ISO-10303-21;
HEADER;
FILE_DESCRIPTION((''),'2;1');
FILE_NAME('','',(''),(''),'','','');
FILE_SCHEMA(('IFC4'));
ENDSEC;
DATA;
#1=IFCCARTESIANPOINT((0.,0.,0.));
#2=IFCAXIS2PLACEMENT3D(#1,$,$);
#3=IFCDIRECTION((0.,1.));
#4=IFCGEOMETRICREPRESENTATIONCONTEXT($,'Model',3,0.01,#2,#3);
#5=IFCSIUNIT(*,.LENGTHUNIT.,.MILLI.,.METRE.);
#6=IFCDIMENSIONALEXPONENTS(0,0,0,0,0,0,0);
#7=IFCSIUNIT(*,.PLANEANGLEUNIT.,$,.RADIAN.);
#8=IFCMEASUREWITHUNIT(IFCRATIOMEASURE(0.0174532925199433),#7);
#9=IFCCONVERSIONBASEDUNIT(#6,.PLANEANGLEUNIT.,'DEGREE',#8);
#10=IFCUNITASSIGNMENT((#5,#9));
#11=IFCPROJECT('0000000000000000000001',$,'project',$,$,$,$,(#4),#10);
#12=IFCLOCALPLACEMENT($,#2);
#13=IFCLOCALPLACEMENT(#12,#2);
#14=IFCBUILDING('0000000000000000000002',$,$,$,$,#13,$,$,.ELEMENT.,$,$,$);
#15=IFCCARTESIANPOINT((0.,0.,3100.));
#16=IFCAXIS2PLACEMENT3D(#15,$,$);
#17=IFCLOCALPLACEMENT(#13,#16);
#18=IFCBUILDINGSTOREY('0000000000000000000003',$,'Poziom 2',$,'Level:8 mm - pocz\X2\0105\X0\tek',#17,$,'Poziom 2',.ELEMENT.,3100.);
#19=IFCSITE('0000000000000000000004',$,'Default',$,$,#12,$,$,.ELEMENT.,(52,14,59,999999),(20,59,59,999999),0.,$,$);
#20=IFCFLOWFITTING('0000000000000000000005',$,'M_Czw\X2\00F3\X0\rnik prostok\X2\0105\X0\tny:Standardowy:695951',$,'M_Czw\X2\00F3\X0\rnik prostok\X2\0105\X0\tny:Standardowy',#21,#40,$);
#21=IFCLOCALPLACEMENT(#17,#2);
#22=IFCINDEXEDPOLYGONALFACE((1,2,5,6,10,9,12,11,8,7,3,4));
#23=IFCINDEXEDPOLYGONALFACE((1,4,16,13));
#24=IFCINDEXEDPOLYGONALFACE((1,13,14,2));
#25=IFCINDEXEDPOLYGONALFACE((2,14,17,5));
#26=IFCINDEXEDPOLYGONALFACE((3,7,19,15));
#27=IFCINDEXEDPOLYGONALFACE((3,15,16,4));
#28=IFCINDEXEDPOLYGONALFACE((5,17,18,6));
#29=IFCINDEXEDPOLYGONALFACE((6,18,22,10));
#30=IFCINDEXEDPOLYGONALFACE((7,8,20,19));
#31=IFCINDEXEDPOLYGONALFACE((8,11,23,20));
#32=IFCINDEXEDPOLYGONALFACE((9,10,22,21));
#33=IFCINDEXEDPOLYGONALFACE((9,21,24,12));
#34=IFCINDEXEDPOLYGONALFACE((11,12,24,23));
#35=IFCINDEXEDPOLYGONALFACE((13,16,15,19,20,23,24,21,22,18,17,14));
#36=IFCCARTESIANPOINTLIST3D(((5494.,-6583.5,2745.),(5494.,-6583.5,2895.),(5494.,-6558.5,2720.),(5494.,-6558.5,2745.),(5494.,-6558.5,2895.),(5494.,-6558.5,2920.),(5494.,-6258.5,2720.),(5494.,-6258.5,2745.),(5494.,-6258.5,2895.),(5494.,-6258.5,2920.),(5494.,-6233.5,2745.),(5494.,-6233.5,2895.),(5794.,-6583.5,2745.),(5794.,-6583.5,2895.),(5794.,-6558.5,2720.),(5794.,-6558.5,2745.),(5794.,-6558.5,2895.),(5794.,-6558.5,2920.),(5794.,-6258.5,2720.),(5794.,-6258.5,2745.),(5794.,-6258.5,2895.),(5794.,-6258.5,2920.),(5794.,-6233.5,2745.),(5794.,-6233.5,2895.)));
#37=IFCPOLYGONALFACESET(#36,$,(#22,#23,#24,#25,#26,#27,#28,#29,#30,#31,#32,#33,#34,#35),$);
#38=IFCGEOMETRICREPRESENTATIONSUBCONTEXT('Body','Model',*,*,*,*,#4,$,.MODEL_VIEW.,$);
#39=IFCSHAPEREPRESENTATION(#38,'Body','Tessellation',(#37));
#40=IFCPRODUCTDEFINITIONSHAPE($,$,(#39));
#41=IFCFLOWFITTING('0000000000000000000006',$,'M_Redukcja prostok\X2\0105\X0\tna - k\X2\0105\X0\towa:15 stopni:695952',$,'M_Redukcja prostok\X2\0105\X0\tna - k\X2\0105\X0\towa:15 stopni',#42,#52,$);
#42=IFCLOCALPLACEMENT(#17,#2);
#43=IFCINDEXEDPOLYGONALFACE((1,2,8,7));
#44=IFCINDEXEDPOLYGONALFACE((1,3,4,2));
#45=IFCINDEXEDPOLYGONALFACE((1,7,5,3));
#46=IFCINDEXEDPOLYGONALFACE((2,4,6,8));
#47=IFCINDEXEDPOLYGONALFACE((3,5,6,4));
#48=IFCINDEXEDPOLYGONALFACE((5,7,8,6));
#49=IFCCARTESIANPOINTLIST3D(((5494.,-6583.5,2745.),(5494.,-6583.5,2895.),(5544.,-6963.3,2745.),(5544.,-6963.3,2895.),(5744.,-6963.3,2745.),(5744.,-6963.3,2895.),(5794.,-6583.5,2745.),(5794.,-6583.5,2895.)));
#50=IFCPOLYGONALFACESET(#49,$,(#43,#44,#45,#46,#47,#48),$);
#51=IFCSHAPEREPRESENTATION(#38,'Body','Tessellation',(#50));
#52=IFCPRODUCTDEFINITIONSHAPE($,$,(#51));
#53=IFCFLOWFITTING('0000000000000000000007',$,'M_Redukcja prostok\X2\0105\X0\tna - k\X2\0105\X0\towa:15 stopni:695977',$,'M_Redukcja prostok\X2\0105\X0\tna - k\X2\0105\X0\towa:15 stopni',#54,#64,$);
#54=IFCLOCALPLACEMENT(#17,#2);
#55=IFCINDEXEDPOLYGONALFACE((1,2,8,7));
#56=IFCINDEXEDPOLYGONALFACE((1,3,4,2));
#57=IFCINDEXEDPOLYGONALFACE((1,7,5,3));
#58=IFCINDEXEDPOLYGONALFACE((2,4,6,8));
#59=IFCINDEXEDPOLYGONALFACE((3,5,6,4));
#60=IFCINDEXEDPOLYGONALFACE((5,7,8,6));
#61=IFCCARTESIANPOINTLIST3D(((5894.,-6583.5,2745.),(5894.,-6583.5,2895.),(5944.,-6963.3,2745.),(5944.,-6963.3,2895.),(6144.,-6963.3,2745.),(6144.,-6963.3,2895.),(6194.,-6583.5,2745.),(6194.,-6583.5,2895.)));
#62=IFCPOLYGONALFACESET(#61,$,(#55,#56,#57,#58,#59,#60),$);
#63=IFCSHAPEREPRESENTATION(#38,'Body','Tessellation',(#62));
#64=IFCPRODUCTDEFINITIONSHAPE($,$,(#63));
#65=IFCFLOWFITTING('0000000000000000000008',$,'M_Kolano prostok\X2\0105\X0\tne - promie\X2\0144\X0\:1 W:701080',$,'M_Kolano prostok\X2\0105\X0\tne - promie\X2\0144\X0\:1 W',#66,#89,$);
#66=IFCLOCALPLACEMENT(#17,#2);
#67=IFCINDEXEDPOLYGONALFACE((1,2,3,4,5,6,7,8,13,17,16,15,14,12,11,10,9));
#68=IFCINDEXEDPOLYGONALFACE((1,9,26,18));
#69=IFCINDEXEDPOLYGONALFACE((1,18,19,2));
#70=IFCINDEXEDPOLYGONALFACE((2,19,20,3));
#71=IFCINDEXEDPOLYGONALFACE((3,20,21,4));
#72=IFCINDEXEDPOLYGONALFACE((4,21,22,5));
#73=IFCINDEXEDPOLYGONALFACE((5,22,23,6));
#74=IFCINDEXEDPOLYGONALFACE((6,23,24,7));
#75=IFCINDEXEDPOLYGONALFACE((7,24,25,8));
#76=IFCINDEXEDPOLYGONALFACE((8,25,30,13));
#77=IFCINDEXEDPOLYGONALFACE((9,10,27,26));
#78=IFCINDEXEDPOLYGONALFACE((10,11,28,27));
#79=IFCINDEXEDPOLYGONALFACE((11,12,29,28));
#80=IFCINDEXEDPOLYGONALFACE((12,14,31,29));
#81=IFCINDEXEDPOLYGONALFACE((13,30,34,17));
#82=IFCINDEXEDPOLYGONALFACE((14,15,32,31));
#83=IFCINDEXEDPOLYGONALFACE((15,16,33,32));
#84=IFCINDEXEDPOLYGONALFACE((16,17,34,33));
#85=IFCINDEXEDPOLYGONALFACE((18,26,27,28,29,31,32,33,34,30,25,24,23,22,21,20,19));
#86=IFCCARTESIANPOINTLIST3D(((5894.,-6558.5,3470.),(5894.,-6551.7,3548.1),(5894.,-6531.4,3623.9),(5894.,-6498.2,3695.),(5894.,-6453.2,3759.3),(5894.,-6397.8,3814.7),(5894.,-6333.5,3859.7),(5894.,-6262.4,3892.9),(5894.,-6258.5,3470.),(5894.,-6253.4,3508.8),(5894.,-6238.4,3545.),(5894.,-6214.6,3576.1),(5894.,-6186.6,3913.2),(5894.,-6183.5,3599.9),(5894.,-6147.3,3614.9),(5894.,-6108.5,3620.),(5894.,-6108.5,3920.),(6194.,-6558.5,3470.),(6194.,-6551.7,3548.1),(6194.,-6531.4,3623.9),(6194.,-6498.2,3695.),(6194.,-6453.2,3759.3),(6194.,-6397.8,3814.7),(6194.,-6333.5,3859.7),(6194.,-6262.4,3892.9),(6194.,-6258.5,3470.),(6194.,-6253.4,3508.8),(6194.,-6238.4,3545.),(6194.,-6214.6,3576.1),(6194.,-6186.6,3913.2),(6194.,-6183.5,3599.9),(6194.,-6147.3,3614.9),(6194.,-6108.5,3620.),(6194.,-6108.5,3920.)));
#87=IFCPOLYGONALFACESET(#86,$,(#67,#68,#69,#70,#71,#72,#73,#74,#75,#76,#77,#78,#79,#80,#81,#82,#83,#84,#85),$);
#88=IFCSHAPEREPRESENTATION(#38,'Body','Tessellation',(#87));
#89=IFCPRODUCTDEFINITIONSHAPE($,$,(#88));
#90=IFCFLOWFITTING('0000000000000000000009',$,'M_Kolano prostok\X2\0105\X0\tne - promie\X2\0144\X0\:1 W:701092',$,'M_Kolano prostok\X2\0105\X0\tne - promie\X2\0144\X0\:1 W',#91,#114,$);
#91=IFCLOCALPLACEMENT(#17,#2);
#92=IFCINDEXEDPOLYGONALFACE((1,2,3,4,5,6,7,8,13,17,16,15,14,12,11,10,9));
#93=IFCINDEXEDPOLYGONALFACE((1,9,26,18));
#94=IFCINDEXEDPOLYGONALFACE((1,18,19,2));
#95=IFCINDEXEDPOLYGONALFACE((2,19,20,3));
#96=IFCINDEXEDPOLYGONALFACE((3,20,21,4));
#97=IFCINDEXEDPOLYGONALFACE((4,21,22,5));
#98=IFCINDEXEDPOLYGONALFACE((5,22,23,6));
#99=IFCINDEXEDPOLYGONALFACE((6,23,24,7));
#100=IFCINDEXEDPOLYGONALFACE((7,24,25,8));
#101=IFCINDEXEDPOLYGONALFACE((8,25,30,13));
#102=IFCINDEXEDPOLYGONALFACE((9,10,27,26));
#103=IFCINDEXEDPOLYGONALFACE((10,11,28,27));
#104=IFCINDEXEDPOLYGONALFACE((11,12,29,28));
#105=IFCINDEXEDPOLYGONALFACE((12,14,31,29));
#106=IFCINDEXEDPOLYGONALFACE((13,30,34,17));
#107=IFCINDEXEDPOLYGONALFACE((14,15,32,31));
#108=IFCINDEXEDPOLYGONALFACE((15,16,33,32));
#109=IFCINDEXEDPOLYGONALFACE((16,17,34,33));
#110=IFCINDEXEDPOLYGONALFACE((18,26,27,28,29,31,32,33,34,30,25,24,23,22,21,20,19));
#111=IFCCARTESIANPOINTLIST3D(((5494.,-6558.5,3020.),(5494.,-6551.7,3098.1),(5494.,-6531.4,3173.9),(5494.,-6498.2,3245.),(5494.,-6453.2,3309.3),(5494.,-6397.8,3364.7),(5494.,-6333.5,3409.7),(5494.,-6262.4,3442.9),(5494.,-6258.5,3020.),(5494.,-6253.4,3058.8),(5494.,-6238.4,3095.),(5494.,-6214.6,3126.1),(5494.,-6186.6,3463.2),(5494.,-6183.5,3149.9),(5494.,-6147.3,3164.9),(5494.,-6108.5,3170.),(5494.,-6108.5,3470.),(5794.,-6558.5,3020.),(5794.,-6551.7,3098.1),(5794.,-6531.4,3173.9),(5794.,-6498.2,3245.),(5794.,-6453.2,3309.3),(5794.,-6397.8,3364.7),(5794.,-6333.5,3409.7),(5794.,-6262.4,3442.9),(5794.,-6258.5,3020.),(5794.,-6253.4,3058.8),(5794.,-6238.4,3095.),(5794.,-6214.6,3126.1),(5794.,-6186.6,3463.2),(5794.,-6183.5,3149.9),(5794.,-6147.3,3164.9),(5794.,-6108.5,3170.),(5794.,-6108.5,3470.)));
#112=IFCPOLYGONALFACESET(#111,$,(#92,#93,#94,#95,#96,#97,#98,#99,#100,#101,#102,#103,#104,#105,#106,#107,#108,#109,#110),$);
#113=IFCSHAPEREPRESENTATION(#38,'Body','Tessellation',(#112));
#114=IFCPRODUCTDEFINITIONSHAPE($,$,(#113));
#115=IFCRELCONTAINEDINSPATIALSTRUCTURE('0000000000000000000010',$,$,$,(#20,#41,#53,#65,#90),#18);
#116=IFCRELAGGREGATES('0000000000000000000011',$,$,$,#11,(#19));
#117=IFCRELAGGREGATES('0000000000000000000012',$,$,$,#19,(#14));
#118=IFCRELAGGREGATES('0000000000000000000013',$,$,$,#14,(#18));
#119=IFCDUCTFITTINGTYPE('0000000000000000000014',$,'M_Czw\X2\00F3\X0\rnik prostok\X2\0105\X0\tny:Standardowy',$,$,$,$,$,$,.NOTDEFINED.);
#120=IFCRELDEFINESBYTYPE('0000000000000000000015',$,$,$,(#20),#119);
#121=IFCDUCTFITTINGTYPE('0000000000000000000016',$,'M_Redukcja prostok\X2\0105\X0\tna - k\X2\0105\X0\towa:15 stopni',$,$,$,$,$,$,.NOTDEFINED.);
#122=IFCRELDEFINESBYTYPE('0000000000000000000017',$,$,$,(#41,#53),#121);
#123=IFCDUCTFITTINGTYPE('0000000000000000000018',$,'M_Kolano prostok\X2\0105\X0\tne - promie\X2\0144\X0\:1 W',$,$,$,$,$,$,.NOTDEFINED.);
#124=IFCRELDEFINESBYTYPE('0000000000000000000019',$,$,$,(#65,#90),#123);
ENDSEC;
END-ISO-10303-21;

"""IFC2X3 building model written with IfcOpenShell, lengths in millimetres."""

from ifc_helpers import new_model, entity, si_unit, converted_unit, direction, frame, frame_2d, origin, place, context, subcontext, project, spatial, polyline, circle_curve, parameter, trimmed, segment, composite_curve, outline, extrude, source, transform, mapped, type_object, type_shapes, element, save


model = new_model("IFC2X3")

# Units and contexts
model_context = context("Model", 3, precision=0.01, world=origin(), true_north=direction((0.0, 1.0)))
body_context = subcontext(model_context, "Body", "Model", "MODEL_VIEW")
ifc_project = project(units=[si_unit("LENGTHUNIT", "METRE", prefix="MILLI"), converted_unit("PLANEANGLEUNIT", "DEGREE", entity("IfcRatioMeasure", 0.0174532925199433), si_unit("PLANEANGLEUNIT", "RADIAN"), dimensions=[0, 0, 0, 0, 0, 0, 0])], contexts=[model_context])

# Site, building, storey
site_placement = place(None, origin())
site = spatial("IfcSite", under=ifc_project, at=site_placement, Name="Default", CompositionType="ELEMENT", RefLatitude=(52, 14, 59, 999999), RefLongitude=(20, 59, 59, 999999), RefElevation=0.0)
building_placement = place(site_placement, origin())
building = spatial("IfcBuilding", under=site, at=building_placement, CompositionType="ELEMENT")
storey_placement = place(building_placement, frame((0.0, 0.0, 3100.0)))
storey = spatial("IfcBuildingStorey", under=building, at=storey_placement, Name="Poziom 2", ObjectType="Level:8 mm - początek", LongName="Poziom 2", CompositionType="ELEMENT", Elevation=3100.0)

# Flow fittings
duct_fitting_type_1 = type_object("IfcDuctFittingType", Name="M_Czwórnik prostokątny:Standardowy", PredefinedType="NOTDEFINED")
shared_shape_1 = source(origin(), body_context, "Body", "SweptSolid", [
    extrude(outline(polyline([(-175.0, 75.0), (-175.0, -75.0), (-150.0, -75.0), (-150.0, -100.0), (150.0, -100.0), (150.0, -75.0), (175.0, -75.0), (175.0, 75.0), (150.0, 75.0), (150.0, 100.0), (-150.0, 100.0), (-150.0, 75.0), (-175.0, 75.0)])), frame((0.0, 0.0, -150.0), z_axis=(0.0, 0.0, -1.0), x_axis=(0.0, 1.0, 0.0)), (0.0, 0.0, -1.0), 300.0),
])
type_shapes(duct_fitting_type_1, [shared_shape_1])
for number, where, z_axis, x_axis, name in (
    (1, (5644.0, -6408.5, 2820.0), (-1.0, 0.0, 0.0), (0.0, 0.0, 1.0), "M_Czwórnik prostokątny:Standardowy:695951"),
):
    element("IfcFlowFitting", number, at=place(storey_placement, frame(where, z_axis=z_axis, x_axis=x_axis)), inside=storey, type_object=duct_fitting_type_1, Name=name, ObjectType="M_Czwórnik prostokątny:Standardowy", context=body_context, shape_type="MappedRepresentation", body=[
        mapped(shared_shape_1, transform((0.0, 0.0, 0.0), scale=1.0)),
    ])
duct_fitting_type_2 = type_object("IfcDuctFittingType", Name="M_Redukcja prostokątna - kątowa:15 stopni", PredefinedType="NOTDEFINED")
shared_shape_2 = source(origin(), body_context, "Body", "SweptSolid", [
    extrude(outline(polyline([(-150.0, -189.9), (150.0, -189.9), (100.0, 189.9), (-100.0, 189.9), (-150.0, -189.9)])), frame((189.9, 0.0, -75.0), z_axis=(0.0, 0.0, 1.0), x_axis=(0.0, -1.0, 0.0)), (0.0, 0.0, 1.0), 150.0),
])
type_shapes(duct_fitting_type_2, [shared_shape_2])
for number, where, z_axis, x_axis, name in (
    (2, (5644.0, -6583.5, 2820.0), (0.0, 0.0, 1.0), (0.0, -1.0, 0.0), "M_Redukcja prostokątna - kątowa:15 stopni:695952"),
    (3, (6044.0, -6583.5, 2820.0), (0.0, 0.0, 1.0), (0.0, -1.0, 0.0), "M_Redukcja prostokątna - kątowa:15 stopni:695977"),
):
    element("IfcFlowFitting", number, at=place(storey_placement, frame(where, z_axis=z_axis, x_axis=x_axis)), inside=storey, type_object=duct_fitting_type_2, Name=name, ObjectType="M_Redukcja prostokątna - kątowa:15 stopni", context=body_context, shape_type="MappedRepresentation", body=[
        mapped(shared_shape_2, transform((0.0, 0.0, 0.0), scale=1.0)),
    ])
duct_fitting_type_3 = type_object("IfcDuctFittingType", Name="M_Kolano prostokątne - promień:1 W", PredefinedType="NOTDEFINED")
shared_shape_3 = source(origin(), body_context, "Body", "SweptSolid", [
    extrude(outline(composite_curve([segment(polyline([(-300.0, -150.0), (0.0, -150.0)]), True, "CONTINUOUS"), segment(trimmed(circle_curve(frame_2d((150.0, -150.0), x_axis=(0.0, 1.0)), 150.0), [parameter(0.0)], [parameter(90.0)], True, "PARAMETER"), False, "CONTINUOUS"), segment(polyline([(150.0, 0.0), (150.0, 300.0)]), True, "CONTINUOUS"), segment(trimmed(circle_curve(frame_2d((150.0, -150.0), x_axis=(0.0, 1.0)), 450.0), [parameter(0.0)], [parameter(90.0)], True, "PARAMETER"), True, "CONTINUOUS")], self_intersect=False)), frame((-150.0, 150.0, -150.0), z_axis=(0.0, 0.0, 1.0), x_axis=(-1.0, 0.0, 0.0)), (0.0, 0.0, 1.0), 300.0),
])
type_shapes(duct_fitting_type_3, [shared_shape_3])
for number, where, z_axis, x_axis, name in (
    (4, (6044.0, -6408.5, 3770.0), (-1.0, 0.0, 0.0), (0.0, 0.0, 1.0), "M_Kolano prostokątne - promień:1 W:701080"),
    (5, (5644.0, -6408.5, 3320.0), (-1.0, 0.0, 0.0), (0.0, 0.0, 1.0), "M_Kolano prostokątne - promień:1 W:701092"),
):
    element("IfcFlowFitting", number, at=place(storey_placement, frame(where, z_axis=z_axis, x_axis=x_axis)), inside=storey, type_object=duct_fitting_type_3, Name=name, ObjectType="M_Kolano prostokątne - promień:1 W", context=body_context, shape_type="MappedRepresentation", body=[
        mapped(shared_shape_3, transform((0.0, 0.0, 0.0), scale=1.0)),
    ])

save(model, "model.ifc")
